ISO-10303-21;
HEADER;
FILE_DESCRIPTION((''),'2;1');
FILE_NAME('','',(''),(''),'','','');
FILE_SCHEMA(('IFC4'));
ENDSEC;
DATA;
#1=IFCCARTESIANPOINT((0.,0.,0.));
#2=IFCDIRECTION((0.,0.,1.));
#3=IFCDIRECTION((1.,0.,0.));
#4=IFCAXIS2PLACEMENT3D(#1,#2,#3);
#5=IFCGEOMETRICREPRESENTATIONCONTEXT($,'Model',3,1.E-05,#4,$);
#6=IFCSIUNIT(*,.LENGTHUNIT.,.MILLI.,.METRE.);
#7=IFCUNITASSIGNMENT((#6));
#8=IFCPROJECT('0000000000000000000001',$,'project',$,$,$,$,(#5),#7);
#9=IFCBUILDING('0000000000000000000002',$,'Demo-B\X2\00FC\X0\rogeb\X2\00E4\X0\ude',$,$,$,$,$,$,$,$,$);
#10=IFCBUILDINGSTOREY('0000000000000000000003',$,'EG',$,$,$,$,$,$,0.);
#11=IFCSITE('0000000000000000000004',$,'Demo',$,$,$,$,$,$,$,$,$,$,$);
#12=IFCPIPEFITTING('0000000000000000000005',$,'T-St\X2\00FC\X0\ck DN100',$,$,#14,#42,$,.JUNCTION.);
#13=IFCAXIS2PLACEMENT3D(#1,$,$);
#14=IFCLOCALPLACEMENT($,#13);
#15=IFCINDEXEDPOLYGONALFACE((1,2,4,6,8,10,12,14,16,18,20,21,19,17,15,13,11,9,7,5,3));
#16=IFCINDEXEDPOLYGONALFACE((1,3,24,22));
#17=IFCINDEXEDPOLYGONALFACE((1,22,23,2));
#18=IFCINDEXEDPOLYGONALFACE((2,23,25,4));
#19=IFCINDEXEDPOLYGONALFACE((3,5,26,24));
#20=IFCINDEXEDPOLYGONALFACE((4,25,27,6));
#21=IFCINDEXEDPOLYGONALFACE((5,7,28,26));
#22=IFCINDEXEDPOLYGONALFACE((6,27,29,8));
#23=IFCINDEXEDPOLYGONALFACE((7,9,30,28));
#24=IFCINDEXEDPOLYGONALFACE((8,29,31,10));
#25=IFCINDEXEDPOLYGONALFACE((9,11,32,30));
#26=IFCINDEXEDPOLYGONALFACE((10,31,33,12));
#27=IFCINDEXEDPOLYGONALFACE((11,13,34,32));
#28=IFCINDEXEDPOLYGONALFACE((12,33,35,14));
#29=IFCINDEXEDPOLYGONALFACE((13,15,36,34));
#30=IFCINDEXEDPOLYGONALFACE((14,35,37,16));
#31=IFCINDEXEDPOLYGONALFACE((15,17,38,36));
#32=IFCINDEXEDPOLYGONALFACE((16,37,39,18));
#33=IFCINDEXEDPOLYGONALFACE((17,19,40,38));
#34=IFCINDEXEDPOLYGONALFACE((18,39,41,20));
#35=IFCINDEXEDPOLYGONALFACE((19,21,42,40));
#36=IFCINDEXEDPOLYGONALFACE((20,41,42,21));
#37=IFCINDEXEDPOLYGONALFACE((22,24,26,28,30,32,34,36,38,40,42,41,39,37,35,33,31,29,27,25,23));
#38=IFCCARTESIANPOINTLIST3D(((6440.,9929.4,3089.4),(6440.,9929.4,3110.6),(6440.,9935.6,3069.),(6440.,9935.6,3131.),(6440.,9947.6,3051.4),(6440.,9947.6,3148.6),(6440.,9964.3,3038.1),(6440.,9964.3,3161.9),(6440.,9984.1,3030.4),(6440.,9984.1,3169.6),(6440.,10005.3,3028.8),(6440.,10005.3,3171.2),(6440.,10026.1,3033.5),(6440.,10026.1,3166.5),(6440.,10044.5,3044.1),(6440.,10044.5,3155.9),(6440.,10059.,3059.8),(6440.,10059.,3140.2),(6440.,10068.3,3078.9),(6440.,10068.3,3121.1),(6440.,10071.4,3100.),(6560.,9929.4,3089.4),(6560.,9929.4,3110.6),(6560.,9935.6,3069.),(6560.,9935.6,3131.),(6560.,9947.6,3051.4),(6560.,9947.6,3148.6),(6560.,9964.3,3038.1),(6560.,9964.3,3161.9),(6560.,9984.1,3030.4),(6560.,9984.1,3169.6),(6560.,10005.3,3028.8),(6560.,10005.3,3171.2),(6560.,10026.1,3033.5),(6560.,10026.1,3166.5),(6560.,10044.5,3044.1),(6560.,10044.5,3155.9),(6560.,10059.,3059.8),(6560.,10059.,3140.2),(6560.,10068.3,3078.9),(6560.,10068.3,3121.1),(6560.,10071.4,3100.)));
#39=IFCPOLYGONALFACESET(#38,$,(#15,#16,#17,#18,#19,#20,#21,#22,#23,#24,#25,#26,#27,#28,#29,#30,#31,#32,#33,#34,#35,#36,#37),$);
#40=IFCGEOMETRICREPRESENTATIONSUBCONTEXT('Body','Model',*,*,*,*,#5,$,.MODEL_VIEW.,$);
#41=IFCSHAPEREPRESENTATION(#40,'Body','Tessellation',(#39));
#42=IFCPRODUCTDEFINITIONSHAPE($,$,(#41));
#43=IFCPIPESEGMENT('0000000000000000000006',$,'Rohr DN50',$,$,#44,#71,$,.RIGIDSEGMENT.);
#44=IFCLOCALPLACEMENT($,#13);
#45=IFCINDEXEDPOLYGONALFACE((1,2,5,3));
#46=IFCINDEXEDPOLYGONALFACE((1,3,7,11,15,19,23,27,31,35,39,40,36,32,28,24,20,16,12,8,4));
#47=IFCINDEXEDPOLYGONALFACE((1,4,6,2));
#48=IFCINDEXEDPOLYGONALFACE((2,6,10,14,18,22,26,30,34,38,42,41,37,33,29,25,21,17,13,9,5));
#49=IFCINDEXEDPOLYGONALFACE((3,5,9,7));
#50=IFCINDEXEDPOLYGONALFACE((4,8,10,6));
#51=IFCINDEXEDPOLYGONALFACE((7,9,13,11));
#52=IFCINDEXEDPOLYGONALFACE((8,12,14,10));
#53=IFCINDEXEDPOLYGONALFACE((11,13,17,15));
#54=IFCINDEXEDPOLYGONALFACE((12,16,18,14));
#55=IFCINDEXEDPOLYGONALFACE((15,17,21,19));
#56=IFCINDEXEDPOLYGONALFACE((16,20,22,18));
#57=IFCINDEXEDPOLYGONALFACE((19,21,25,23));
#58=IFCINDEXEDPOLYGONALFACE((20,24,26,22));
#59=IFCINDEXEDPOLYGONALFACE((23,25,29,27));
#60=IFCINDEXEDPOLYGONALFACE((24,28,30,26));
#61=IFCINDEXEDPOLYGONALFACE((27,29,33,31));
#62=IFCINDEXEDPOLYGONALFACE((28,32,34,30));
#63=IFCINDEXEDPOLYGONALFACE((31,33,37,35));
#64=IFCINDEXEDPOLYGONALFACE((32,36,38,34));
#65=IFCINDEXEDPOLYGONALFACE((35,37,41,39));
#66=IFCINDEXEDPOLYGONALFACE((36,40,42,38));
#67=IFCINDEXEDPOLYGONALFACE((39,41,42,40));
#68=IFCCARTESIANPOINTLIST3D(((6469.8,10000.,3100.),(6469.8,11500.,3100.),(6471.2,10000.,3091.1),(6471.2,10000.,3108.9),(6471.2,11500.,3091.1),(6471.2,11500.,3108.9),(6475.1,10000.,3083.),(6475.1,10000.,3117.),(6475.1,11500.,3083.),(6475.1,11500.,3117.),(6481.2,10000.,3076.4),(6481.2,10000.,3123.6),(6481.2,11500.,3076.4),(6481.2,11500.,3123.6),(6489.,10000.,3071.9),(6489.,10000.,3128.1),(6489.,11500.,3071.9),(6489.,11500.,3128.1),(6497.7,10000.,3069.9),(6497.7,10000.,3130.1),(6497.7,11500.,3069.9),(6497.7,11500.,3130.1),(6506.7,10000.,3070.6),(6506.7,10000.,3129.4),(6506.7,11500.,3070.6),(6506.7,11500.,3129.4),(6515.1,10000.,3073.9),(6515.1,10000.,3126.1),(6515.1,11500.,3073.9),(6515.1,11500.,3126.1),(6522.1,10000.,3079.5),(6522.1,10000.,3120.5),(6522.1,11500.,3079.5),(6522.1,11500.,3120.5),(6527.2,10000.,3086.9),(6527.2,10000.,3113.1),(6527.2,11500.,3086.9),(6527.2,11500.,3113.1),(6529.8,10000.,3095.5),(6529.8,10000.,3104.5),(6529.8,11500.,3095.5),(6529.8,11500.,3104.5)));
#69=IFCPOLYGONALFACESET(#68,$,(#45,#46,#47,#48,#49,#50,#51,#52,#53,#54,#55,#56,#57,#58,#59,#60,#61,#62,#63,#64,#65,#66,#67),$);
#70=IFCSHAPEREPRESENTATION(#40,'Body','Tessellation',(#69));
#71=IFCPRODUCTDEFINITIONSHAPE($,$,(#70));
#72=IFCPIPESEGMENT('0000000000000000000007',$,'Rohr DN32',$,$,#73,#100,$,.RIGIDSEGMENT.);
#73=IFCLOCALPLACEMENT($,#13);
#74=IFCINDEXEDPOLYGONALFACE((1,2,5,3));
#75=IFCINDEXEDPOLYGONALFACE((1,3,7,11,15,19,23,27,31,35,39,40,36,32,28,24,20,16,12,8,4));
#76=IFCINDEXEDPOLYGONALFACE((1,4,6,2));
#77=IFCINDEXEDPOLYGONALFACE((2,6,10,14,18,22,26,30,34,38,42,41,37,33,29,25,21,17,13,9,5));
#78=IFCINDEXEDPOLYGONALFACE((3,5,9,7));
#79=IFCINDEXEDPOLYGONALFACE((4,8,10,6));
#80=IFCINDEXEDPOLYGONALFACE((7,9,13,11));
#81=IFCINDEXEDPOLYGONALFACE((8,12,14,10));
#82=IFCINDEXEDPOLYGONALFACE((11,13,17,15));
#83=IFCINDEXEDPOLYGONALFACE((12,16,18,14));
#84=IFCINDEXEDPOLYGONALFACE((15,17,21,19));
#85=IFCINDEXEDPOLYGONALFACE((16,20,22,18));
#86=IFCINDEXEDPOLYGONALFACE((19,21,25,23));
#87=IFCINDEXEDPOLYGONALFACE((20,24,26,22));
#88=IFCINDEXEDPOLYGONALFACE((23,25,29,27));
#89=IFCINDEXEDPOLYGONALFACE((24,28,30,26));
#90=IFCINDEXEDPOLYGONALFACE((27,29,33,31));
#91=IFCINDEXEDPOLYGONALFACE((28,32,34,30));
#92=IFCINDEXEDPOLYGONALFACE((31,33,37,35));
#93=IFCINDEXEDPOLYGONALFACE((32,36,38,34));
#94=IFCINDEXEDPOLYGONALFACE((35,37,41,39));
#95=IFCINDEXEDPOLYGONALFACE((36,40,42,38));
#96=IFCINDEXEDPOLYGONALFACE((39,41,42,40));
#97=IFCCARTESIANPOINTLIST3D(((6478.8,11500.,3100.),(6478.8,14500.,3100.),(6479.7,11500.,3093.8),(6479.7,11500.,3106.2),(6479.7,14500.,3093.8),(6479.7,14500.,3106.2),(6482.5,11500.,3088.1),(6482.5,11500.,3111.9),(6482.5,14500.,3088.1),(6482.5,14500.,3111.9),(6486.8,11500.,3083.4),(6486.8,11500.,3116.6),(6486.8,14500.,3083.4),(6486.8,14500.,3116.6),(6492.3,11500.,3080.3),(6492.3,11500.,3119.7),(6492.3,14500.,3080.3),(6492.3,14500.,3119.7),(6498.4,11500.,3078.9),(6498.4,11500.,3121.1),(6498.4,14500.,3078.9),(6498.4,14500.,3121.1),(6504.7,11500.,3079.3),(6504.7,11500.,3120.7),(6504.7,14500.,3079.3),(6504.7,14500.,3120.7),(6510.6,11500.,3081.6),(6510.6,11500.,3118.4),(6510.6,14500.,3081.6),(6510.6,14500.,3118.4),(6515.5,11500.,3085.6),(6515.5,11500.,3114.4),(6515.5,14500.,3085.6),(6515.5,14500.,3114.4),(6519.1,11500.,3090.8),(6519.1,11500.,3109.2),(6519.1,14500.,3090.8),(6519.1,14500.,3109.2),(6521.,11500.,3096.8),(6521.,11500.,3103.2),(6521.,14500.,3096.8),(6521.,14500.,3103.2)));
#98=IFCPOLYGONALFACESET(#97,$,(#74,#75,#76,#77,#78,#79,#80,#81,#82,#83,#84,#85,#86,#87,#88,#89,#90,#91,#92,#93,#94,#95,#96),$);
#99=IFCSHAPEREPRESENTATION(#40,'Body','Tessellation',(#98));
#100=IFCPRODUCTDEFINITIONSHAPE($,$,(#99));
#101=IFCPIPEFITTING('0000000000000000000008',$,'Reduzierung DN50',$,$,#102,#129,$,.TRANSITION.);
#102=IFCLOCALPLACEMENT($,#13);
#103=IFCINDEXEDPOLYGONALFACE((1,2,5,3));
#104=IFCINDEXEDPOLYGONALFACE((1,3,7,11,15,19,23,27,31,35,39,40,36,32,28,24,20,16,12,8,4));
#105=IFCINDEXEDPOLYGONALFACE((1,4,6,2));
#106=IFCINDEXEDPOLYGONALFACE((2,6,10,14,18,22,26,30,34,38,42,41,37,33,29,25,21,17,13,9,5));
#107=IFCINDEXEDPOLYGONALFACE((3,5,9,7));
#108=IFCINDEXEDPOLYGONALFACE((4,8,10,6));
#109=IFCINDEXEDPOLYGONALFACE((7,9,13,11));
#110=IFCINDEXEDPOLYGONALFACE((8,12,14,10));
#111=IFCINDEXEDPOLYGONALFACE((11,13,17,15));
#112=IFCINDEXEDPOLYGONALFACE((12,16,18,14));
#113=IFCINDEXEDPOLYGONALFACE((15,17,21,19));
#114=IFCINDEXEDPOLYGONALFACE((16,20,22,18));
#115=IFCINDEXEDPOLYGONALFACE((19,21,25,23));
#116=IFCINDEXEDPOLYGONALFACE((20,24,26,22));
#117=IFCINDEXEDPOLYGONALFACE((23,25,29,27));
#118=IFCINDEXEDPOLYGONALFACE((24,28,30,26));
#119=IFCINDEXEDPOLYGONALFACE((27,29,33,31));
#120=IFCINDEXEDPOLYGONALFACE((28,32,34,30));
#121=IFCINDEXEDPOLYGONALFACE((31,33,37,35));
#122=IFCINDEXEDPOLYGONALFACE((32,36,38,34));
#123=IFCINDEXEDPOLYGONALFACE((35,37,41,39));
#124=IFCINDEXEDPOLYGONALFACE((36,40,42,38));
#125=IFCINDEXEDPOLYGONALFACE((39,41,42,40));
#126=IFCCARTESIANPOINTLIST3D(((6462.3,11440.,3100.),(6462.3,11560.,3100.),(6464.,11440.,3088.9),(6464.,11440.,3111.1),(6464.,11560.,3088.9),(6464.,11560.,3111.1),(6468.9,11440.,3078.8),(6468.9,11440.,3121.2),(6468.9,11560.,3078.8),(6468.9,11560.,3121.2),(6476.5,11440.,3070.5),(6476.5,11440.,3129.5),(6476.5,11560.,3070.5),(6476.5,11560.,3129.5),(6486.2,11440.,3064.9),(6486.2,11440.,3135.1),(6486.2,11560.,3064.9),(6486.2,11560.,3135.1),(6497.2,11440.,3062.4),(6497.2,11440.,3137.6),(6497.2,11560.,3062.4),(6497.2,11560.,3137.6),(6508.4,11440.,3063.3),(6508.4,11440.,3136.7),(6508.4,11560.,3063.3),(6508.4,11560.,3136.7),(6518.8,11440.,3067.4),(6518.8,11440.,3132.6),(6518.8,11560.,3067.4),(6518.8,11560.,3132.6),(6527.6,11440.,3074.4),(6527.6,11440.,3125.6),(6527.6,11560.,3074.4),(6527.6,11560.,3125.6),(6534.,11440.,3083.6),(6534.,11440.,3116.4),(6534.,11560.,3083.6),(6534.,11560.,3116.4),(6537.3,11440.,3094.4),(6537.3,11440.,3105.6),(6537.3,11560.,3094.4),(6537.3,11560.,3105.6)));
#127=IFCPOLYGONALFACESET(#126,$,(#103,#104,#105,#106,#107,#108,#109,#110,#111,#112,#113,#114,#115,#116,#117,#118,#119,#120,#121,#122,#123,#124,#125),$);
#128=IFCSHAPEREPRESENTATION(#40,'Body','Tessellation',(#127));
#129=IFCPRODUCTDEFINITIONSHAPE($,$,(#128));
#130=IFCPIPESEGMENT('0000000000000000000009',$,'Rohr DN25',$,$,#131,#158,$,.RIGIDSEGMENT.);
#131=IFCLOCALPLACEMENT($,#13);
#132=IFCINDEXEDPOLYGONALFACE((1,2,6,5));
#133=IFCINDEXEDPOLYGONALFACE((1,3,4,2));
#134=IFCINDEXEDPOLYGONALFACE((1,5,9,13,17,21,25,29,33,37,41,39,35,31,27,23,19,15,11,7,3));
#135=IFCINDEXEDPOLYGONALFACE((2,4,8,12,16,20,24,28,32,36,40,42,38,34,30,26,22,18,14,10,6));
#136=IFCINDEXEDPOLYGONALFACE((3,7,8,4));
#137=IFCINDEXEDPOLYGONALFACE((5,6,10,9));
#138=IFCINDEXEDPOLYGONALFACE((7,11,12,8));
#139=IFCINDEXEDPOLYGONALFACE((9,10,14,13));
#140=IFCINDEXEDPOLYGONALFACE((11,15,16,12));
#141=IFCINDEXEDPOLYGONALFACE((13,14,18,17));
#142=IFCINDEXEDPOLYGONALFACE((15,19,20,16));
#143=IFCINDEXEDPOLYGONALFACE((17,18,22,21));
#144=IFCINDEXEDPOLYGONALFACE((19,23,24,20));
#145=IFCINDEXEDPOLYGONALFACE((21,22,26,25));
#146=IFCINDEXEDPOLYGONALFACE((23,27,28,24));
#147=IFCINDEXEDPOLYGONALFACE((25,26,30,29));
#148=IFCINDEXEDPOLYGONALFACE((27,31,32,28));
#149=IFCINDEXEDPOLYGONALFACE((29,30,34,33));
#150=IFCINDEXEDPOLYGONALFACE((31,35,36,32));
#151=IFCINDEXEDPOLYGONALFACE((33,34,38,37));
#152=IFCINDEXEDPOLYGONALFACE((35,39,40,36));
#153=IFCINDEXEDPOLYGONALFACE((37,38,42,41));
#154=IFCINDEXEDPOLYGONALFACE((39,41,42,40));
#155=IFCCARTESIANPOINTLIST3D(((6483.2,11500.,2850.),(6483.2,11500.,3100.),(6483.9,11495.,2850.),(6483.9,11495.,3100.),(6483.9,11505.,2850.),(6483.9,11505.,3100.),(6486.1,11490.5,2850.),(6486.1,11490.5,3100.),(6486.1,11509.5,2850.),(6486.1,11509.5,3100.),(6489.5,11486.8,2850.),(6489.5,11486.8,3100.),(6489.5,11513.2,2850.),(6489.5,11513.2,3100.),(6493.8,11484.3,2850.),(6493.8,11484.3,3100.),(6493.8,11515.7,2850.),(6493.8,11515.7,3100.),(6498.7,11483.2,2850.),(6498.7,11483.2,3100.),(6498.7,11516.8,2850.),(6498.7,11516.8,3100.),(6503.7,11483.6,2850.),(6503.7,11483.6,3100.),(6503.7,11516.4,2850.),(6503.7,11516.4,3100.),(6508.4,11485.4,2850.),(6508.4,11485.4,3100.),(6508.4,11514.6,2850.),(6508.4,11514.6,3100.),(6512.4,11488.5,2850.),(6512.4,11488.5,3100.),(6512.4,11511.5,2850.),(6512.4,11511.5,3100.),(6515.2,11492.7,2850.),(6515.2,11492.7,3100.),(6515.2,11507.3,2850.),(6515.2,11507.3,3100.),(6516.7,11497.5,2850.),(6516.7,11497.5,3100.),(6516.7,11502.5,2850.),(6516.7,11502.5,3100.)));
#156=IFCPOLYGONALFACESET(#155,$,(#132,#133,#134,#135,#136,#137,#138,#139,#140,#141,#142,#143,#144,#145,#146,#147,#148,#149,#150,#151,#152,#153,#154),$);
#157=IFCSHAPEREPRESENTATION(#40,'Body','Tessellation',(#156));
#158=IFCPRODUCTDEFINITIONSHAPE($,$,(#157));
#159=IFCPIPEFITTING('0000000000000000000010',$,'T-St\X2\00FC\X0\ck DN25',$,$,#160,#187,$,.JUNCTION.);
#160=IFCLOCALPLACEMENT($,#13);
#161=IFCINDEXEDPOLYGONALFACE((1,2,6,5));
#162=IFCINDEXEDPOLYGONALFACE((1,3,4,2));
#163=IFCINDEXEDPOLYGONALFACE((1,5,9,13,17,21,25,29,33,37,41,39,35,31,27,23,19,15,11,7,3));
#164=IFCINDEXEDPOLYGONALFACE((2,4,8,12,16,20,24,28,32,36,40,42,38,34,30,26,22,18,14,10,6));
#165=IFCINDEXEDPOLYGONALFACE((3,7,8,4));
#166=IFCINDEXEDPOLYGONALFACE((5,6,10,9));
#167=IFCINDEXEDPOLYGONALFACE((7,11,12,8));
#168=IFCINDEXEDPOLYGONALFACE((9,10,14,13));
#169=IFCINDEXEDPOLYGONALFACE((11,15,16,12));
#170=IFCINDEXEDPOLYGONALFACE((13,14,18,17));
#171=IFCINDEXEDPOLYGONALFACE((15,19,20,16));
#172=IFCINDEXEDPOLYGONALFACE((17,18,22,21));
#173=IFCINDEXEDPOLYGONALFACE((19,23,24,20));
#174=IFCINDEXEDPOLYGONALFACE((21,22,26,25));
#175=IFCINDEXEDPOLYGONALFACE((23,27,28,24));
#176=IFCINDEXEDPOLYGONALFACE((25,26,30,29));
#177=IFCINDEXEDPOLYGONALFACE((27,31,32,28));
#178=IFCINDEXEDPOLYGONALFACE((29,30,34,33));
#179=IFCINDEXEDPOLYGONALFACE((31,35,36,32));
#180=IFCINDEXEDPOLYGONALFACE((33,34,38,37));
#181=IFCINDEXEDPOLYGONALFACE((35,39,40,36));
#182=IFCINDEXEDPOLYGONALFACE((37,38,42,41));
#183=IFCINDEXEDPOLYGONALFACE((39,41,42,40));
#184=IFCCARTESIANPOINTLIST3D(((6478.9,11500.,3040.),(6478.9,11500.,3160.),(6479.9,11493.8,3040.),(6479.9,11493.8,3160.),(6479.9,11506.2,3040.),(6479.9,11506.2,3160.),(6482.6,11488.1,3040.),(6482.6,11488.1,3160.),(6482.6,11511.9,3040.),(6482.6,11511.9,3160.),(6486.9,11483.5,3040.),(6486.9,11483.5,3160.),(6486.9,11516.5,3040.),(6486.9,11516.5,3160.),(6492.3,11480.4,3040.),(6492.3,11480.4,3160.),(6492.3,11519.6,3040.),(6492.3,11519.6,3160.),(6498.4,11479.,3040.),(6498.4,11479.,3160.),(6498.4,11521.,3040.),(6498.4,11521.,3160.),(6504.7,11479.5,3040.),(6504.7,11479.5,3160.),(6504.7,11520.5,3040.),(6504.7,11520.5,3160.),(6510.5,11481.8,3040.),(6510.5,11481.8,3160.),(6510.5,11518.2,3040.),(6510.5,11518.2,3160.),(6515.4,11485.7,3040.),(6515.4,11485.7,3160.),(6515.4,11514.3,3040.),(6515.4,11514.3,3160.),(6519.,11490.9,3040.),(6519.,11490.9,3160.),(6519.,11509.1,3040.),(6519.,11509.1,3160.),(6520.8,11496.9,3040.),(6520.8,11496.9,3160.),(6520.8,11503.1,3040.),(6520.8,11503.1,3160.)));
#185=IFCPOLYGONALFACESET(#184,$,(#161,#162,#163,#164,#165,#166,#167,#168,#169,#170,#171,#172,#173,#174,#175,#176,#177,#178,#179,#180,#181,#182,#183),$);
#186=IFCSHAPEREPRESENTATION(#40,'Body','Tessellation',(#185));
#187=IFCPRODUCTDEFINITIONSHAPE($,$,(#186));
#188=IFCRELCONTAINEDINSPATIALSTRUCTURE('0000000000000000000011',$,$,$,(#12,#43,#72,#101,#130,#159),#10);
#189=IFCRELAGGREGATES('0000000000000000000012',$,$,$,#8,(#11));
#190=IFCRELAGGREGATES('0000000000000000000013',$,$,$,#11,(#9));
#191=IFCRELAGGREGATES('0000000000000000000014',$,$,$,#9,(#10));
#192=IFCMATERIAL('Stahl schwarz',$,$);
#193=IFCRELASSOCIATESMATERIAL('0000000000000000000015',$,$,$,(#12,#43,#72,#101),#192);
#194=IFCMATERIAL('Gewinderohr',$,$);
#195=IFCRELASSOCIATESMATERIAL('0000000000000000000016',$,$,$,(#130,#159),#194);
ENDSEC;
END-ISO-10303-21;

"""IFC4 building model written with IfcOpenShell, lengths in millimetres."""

from ifc_helpers import new_model, si_unit, frame, origin_with_axes, place, context, subcontext, project, spatial, circle, extrude, material, element, save


model = new_model("IFC4")

# Units and contexts
model_context = context("Model", 3, precision=1e-05, world=origin_with_axes())
body_context = subcontext(model_context, "Body", "Model", "MODEL_VIEW")
ifc_project = project(units=[si_unit("LENGTHUNIT", "METRE", prefix="MILLI")], contexts=[model_context])

# Site, building, storey
site = spatial("IfcSite", under=ifc_project, Name="Demo")
building = spatial("IfcBuilding", under=site, Name="Demo-Bürogebäude")
storey = spatial("IfcBuildingStorey", under=building, Name="EG", Elevation=0.0)

# Shared definitions
ifc_material_1 = material(Name="Stahl schwarz")

# Shared definitions
ifc_material_2 = material(Name="Gewinderohr")

# Pipe fitting
pipe_fitting_1_placement = place(None, frame((6440.0, 10000.0, 3100.0), z_axis=(1.0, 0.0, 0.0), x_axis=(0.0, 1.0, 0.0)))
element("IfcPipeFitting", 1, at=pipe_fitting_1_placement, inside=storey, material=ifc_material_1, Name="T-Stück DN100", PredefinedType="JUNCTION", context=body_context, shape_type="SweptSolid", body=[
    extrude(circle(Radius=71.4), origin_with_axes(), (0.0, 0.0, 1.0), 120.0),
])

# Pipe segments
pipe_segment_1_placement = place(None, frame((6500.0, 10000.0, 3100.0), z_axis=(0.0, 1.0, 0.0), x_axis=(-1.0, 0.0, 0.0)))
element("IfcPipeSegment", 2, at=pipe_segment_1_placement, inside=storey, material=ifc_material_1, Name="Rohr DN50", PredefinedType="RIGIDSEGMENT", context=body_context, shape_type="SweptSolid", body=[
    extrude(circle(Radius=30.1), origin_with_axes(), (0.0, 0.0, 1.0), 1500.0),
])
pipe_segment_2_placement = place(None, frame((6500.0, 11500.0, 3100.0), z_axis=(0.0, 1.0, 0.0), x_axis=(-1.0, 0.0, 0.0)))
element("IfcPipeSegment", 3, at=pipe_segment_2_placement, inside=storey, material=ifc_material_1, Name="Rohr DN32", PredefinedType="RIGIDSEGMENT", context=body_context, shape_type="SweptSolid", body=[
    extrude(circle(Radius=21.2), origin_with_axes(), (0.0, 0.0, 1.0), 3000.0),
])

# Pipe fitting
pipe_fitting_2_placement = place(None, frame((6500.0, 11440.0, 3100.0), z_axis=(0.0, 1.0, 0.0), x_axis=(-1.0, 0.0, 0.0)))
element("IfcPipeFitting", 4, at=pipe_fitting_2_placement, inside=storey, material=ifc_material_1, Name="Reduzierung DN50", PredefinedType="TRANSITION", context=body_context, shape_type="SweptSolid", body=[
    extrude(circle(Radius=37.7), origin_with_axes(), (0.0, 0.0, 1.0), 120.0),
])

# Pipe segment
pipe_segment_3_placement = place(None, frame((6500.0, 11500.0, 3100.0), z_axis=(0.0, 0.0, -1.0), x_axis=(-1.0, 0.0, 0.0)))
element("IfcPipeSegment", 5, at=pipe_segment_3_placement, inside=storey, material=ifc_material_2, Name="Rohr DN25", PredefinedType="RIGIDSEGMENT", context=body_context, shape_type="SweptSolid", body=[
    extrude(circle(Radius=16.9), origin_with_axes(), (0.0, 0.0, 1.0), 250.0),
])

# Pipe fitting
pipe_fitting_3_placement = place(None, frame((6500.0, 11500.0, 3160.0), z_axis=(0.0, 0.0, -1.0), x_axis=(-1.0, 0.0, 0.0)))
element("IfcPipeFitting", 6, at=pipe_fitting_3_placement, inside=storey, material=ifc_material_2, Name="T-Stück DN25", PredefinedType="JUNCTION", context=body_context, shape_type="SweptSolid", body=[
    extrude(circle(Radius=21.1), origin_with_axes(), (0.0, 0.0, 1.0), 120.0),
])

save(model, "model.ifc")
